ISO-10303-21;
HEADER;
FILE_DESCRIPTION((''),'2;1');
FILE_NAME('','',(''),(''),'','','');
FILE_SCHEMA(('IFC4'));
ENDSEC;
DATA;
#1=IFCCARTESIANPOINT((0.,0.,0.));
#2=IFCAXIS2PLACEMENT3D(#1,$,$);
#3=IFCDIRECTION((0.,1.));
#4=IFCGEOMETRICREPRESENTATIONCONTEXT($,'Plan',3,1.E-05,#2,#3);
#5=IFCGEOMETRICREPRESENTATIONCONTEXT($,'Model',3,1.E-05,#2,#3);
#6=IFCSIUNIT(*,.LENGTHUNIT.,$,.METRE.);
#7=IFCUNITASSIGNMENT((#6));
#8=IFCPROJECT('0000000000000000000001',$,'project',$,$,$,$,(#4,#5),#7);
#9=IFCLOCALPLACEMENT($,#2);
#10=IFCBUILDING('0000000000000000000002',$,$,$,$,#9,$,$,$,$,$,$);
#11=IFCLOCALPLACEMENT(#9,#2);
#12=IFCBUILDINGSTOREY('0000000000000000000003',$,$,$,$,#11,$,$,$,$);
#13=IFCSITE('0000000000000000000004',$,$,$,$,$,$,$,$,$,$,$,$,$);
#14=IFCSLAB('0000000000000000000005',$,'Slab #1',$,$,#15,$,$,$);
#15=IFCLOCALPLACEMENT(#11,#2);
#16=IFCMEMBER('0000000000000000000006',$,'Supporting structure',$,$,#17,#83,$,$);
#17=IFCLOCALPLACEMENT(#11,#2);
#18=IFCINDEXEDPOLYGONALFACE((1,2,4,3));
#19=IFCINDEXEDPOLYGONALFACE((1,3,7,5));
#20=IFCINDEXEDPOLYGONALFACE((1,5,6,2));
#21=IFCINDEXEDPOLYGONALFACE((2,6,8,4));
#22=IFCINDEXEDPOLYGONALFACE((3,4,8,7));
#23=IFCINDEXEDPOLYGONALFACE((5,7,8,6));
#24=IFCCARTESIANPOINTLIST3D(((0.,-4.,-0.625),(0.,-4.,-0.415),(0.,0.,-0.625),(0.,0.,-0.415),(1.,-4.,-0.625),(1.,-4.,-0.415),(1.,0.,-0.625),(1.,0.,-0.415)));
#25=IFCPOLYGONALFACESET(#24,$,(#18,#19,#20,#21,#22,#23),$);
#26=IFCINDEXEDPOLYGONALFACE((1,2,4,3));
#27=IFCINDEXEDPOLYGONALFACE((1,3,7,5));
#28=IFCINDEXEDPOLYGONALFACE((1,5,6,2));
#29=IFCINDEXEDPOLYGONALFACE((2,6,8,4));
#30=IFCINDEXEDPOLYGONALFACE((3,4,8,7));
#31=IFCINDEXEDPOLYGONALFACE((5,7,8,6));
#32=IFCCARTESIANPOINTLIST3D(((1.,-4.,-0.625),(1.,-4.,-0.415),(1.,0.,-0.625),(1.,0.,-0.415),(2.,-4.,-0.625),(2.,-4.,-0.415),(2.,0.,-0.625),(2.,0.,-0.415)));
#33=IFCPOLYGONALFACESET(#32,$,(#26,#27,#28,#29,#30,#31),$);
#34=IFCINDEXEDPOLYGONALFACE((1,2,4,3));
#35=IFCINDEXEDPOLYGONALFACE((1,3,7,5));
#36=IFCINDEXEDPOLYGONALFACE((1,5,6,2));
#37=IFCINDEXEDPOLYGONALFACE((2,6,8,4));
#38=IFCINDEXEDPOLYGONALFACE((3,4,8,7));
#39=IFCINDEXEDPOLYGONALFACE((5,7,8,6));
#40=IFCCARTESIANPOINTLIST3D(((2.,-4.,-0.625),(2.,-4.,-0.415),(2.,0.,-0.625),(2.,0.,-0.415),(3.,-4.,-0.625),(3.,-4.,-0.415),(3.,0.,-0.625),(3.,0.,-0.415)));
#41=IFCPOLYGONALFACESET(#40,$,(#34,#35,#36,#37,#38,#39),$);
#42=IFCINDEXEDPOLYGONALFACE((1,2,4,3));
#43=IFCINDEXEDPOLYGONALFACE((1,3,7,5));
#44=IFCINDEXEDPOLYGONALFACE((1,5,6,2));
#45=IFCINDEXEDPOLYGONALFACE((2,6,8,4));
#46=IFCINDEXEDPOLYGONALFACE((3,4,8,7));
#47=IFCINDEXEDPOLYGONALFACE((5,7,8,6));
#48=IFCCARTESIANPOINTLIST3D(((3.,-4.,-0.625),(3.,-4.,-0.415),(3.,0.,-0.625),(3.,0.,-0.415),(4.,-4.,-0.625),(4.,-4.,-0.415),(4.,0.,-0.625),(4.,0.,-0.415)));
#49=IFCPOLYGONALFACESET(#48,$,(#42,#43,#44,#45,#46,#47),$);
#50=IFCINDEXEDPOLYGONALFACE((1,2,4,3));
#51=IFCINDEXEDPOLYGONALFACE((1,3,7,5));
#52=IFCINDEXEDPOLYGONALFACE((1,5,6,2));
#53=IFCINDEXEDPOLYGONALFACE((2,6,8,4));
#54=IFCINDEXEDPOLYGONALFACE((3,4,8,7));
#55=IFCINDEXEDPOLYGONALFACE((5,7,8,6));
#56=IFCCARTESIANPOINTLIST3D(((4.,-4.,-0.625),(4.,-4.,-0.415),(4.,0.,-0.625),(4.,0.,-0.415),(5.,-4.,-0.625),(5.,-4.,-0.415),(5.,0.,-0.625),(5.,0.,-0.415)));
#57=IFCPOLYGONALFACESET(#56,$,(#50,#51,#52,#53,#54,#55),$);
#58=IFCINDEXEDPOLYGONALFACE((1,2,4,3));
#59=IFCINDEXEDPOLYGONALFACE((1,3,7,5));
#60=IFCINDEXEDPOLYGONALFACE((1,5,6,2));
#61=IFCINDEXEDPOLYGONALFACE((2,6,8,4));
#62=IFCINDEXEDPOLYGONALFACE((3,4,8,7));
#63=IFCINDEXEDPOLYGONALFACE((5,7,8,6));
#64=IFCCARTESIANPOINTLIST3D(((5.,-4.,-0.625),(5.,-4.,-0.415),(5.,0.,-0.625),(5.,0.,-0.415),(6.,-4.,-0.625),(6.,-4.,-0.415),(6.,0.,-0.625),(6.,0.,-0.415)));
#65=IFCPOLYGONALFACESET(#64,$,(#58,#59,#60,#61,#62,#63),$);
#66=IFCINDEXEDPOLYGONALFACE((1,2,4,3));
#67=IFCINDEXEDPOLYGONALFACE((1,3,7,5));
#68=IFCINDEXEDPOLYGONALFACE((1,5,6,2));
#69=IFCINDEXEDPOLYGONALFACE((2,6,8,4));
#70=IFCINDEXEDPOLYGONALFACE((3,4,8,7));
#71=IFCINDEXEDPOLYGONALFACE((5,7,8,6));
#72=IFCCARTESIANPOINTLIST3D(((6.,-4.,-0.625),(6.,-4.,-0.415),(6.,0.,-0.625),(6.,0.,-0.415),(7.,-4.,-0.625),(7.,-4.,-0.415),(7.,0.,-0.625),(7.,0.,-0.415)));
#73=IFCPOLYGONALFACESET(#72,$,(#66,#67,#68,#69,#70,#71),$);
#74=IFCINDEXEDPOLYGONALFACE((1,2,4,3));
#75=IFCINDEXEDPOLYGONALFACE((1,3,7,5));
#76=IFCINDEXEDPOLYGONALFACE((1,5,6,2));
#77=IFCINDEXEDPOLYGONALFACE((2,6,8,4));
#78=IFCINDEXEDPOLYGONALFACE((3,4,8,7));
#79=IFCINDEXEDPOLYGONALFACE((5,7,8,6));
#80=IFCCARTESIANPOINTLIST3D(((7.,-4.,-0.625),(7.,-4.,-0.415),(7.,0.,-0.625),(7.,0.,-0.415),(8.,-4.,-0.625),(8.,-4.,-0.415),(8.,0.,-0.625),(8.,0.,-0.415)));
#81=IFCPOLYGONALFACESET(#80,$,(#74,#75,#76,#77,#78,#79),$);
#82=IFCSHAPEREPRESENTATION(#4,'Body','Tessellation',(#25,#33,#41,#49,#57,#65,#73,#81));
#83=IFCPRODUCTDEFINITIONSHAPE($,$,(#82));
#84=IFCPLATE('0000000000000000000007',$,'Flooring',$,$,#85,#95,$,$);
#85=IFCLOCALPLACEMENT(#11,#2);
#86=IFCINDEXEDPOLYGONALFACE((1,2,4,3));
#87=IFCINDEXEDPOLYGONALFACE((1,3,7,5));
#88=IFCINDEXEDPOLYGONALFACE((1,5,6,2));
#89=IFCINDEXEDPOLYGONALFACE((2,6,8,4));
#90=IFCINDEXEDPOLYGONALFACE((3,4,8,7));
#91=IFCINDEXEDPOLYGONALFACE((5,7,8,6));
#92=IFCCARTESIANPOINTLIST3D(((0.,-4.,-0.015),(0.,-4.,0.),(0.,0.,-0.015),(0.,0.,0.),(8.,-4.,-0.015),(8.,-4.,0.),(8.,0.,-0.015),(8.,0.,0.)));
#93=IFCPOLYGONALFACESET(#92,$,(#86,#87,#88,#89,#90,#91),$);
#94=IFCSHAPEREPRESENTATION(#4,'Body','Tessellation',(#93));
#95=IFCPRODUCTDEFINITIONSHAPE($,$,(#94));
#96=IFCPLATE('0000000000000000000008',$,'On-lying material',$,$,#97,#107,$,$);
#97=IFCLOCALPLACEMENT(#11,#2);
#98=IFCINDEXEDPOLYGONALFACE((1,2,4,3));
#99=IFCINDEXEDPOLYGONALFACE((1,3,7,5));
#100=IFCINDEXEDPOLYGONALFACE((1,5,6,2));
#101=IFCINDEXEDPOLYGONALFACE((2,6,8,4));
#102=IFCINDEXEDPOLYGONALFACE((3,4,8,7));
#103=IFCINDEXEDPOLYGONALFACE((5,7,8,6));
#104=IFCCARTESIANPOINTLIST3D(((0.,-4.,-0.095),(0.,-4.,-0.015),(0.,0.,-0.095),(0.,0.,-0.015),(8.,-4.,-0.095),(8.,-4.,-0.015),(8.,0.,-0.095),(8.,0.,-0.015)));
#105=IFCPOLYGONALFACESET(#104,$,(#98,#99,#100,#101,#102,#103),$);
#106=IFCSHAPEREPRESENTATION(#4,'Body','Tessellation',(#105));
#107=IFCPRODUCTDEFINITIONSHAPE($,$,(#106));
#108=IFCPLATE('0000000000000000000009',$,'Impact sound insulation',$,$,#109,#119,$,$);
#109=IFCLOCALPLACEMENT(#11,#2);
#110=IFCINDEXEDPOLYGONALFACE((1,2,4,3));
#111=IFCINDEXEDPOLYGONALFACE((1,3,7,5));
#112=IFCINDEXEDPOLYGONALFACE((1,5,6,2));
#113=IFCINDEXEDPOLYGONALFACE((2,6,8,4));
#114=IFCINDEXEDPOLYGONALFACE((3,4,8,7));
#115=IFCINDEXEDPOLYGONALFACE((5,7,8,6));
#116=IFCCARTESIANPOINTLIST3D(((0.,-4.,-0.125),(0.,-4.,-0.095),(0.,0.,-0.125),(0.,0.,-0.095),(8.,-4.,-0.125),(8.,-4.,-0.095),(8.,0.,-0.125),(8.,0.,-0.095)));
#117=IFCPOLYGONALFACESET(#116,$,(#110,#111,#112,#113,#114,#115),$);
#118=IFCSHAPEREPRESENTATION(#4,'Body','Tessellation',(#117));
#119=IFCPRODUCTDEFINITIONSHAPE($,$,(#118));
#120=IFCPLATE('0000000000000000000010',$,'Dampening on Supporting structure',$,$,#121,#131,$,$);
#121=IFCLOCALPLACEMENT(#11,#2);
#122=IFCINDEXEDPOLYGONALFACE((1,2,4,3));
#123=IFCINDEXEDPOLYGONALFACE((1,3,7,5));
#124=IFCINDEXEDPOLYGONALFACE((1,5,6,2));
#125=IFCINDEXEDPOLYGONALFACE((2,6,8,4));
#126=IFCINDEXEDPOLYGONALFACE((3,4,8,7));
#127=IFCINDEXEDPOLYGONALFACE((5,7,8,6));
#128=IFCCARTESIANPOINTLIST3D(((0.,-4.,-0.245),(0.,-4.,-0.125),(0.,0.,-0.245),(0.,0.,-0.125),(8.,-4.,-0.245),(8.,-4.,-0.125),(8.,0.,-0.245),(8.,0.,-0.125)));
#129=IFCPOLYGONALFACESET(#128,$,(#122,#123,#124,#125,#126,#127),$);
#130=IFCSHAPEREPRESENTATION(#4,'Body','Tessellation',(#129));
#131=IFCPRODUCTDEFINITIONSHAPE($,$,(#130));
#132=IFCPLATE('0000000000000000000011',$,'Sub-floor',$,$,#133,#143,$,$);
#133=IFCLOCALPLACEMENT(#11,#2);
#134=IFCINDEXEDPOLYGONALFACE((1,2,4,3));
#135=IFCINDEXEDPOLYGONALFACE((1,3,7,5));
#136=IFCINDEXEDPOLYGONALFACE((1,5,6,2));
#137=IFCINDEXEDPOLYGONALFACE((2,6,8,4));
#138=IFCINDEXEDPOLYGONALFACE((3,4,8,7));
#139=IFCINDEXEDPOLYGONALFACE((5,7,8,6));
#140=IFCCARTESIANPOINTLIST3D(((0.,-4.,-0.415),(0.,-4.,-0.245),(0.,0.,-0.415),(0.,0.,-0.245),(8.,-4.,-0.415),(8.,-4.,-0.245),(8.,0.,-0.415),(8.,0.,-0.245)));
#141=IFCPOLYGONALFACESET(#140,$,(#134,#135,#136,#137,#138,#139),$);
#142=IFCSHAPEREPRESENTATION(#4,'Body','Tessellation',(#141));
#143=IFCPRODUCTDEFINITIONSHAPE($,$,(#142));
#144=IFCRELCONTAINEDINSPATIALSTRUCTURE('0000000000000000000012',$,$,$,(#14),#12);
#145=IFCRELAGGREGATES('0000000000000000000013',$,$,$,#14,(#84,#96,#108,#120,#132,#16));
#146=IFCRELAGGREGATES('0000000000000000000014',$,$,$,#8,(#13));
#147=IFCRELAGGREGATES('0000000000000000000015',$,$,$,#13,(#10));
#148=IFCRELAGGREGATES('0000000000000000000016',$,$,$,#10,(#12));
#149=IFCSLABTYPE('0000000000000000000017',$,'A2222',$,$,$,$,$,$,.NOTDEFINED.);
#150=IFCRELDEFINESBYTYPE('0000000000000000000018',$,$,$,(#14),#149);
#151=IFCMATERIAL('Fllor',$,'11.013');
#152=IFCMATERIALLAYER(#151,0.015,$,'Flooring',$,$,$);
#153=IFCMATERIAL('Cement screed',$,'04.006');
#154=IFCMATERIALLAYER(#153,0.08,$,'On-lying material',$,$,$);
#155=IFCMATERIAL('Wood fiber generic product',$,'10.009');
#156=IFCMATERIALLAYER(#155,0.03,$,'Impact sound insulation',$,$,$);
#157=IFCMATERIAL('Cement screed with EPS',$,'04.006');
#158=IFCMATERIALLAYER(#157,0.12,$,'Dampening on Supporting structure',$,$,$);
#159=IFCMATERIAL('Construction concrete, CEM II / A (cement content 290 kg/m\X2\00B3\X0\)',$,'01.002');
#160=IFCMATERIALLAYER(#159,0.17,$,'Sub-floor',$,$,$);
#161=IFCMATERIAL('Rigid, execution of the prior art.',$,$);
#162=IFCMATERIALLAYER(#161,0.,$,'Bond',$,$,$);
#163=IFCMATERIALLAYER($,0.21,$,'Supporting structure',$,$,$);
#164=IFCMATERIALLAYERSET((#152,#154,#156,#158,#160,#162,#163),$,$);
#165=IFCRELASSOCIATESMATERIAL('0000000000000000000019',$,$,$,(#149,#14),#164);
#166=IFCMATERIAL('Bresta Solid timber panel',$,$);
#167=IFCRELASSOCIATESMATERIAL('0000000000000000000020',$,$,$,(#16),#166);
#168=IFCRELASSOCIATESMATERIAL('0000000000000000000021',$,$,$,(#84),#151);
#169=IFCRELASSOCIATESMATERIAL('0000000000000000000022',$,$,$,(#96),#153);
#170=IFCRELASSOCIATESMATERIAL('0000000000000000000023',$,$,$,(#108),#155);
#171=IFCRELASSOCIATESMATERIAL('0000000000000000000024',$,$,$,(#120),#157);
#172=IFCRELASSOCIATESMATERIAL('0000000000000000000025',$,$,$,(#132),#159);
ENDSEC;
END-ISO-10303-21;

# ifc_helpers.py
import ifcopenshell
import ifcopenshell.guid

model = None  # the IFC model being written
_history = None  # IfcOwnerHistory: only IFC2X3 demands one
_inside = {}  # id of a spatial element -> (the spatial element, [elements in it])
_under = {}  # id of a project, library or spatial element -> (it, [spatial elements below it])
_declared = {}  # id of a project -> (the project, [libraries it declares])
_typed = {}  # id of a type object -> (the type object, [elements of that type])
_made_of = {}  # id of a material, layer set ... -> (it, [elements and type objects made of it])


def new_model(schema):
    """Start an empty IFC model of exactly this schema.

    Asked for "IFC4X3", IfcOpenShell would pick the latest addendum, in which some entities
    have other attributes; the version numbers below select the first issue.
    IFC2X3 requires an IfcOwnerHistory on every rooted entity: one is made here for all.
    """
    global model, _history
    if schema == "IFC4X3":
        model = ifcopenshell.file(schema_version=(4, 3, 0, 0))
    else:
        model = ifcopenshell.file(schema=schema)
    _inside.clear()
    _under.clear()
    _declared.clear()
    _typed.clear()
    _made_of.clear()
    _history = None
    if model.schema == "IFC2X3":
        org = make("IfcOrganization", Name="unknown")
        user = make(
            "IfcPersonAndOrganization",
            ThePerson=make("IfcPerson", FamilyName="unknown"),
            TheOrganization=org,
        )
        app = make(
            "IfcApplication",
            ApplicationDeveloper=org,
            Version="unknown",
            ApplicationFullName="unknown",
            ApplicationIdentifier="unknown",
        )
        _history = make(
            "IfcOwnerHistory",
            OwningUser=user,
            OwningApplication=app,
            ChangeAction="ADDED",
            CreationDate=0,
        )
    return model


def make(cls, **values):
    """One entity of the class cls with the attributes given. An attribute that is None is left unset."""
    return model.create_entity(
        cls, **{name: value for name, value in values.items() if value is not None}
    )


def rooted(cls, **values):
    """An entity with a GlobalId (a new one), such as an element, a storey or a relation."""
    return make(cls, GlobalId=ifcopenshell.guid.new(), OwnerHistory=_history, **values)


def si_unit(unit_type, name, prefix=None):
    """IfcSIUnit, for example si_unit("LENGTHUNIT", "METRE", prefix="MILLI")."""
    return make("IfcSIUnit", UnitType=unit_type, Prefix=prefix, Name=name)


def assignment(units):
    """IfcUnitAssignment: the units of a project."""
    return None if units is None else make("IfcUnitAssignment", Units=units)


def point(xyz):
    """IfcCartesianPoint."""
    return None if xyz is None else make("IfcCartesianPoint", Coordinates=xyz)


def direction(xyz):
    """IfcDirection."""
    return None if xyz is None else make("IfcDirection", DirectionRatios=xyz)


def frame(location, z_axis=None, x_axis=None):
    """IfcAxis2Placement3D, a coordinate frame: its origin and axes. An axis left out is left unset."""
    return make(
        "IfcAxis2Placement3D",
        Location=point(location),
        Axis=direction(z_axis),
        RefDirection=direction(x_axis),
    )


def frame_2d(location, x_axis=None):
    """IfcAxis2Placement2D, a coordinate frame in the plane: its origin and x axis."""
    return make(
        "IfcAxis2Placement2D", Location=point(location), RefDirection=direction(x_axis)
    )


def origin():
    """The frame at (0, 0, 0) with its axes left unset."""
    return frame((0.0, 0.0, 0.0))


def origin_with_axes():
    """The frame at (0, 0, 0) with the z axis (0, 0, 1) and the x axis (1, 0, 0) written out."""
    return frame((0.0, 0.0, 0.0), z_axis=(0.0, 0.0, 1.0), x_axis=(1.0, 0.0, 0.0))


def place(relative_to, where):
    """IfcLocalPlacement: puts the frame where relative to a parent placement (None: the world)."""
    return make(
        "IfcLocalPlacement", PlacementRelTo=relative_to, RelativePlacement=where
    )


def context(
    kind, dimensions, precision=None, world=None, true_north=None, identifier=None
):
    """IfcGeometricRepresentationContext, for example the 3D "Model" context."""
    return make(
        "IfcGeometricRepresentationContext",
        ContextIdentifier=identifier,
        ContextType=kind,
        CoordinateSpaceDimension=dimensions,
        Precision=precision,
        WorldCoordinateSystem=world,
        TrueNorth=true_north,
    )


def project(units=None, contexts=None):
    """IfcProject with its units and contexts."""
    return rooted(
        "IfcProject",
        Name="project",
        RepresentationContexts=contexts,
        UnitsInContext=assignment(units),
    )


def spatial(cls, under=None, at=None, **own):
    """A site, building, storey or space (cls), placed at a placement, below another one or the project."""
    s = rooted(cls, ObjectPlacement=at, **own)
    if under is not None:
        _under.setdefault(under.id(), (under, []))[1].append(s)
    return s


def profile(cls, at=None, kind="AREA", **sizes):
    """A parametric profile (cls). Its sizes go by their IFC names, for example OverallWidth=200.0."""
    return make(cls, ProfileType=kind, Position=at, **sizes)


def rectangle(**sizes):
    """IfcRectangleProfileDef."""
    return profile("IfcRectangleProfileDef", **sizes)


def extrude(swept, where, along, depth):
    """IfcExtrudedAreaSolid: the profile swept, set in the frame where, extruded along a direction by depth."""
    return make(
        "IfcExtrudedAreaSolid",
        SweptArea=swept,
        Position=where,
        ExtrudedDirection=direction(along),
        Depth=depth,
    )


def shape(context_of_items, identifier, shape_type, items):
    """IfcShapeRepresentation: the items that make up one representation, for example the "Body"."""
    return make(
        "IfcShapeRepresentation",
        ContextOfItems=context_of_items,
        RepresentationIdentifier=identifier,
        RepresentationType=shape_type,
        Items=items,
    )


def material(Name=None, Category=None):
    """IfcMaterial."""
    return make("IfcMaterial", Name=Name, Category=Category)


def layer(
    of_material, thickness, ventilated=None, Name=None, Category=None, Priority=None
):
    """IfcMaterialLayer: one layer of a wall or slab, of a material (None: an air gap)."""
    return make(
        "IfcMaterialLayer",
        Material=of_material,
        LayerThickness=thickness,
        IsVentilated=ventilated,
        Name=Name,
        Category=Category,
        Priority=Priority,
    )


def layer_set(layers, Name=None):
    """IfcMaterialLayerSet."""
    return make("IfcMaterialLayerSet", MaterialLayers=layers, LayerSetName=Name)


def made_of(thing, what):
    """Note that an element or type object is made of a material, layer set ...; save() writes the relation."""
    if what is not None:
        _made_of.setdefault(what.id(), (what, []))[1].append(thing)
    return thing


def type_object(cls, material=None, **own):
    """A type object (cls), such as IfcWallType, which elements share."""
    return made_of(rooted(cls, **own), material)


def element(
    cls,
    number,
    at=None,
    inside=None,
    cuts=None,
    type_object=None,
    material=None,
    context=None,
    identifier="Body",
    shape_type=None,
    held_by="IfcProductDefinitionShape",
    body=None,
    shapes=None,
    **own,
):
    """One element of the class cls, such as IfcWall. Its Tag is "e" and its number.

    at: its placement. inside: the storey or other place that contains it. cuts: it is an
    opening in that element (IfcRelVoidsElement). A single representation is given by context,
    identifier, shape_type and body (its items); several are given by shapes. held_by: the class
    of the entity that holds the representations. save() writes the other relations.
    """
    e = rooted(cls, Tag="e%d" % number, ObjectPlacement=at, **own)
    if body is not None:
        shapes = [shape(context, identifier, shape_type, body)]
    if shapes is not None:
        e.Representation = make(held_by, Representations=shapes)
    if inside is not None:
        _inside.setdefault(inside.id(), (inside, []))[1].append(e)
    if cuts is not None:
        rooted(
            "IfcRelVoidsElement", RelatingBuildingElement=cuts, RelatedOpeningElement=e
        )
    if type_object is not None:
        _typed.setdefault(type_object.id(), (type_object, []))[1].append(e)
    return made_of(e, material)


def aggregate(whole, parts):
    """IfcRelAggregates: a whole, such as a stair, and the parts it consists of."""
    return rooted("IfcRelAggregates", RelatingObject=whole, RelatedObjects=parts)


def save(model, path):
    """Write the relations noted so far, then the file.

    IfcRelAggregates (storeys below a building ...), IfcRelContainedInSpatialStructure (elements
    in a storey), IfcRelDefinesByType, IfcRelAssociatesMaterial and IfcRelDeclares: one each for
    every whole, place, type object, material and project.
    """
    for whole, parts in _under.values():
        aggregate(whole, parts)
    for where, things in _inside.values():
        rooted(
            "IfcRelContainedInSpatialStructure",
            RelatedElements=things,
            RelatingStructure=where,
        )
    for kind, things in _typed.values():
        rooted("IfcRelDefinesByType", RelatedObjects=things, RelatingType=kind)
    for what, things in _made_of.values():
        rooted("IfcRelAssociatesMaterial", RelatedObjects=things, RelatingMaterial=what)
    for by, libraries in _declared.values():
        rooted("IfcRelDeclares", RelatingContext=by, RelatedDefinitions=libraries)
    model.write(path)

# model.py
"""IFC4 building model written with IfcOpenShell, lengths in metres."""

from ifc_helpers import new_model, si_unit, direction, frame, frame_2d, origin, origin_with_axes, place, context, project, spatial, rectangle, extrude, material, layer, layer_set, type_object, element, aggregate, save


model = new_model("IFC4")

# Units and contexts
plan_context = context("Plan", 3, precision=1e-05, world=origin(), true_north=direction((0.0, 1.0)))
model_context = context("Model", 3, precision=1e-05, world=origin(), true_north=direction((0.0, 1.0)))
ifc_project = project(units=[si_unit("LENGTHUNIT", "METRE")], contexts=[plan_context, model_context])

# Site, building, storey
site = spatial("IfcSite", under=ifc_project)
building_placement = place(None, origin())
building = spatial("IfcBuilding", under=site, at=building_placement)
storey_placement = place(building_placement, origin())
storey = spatial("IfcBuildingStorey", under=building, at=storey_placement)

# Slab, member, plates
ifc_material_1 = material(Name="Fllor", Category="11.013")
ifc_layer_1 = layer(ifc_material_1, 0.015, Name="Flooring")
ifc_material_2 = material(Name="Cement screed", Category="04.006")
ifc_layer_2 = layer(ifc_material_2, 0.08, Name="On-lying material")
ifc_material_3 = material(Name="Wood fiber generic product", Category="10.009")
ifc_layer_3 = layer(ifc_material_3, 0.03, Name="Impact sound insulation")
ifc_material_4 = material(Name="Cement screed with EPS", Category="04.006")
ifc_layer_4 = layer(ifc_material_4, 0.12, Name="Dampening on Supporting structure")
ifc_material_5 = material(Name="Construction concrete, CEM II / A (cement content 290 kg/m³)", Category="01.002")
ifc_layer_5 = layer(ifc_material_5, 0.17, Name="Sub-floor")
ifc_material_6 = material(Name="Rigid, execution of the prior art.")
ifc_layer_6 = layer(ifc_material_6, 0.0, Name="Bond")
ifc_layer_7 = layer(None, 0.21, Name="Supporting structure")
ifc_layer_set = layer_set([ifc_layer_1, ifc_layer_2, ifc_layer_3, ifc_layer_4, ifc_layer_5, ifc_layer_6, ifc_layer_7])
slab_type = type_object("IfcSlabType", Name="A2222", PredefinedType="NOTDEFINED", material=ifc_layer_set)
slab_placement = place(None, frame((0.0, 0.0, 0.0), z_axis=(0.0, 0.0, -1.0), x_axis=(1.0, 0.0, 0.0)))
slab = element("IfcSlab", 1, at=slab_placement, inside=storey, type_object=slab_type, material=ifc_layer_set, Name="Slab #1")
ifc_material_7 = material(Name="Bresta Solid timber panel")
member_placement = place(slab_placement, origin())
member = element("IfcMember", 2, at=member_placement, material=ifc_material_7, Name="Supporting structure", context=plan_context, shape_type="SweptSolid", body=[
    extrude(rectangle(XDim=1.0, YDim=0.21, at=frame_2d((0.5, 0.105), x_axis=(1.0, 0.0))), frame((0.0, 4.0, 0.415), z_axis=(0.0, -1.0, 0.0), x_axis=(1.0, 0.0, 0.0)), (0.0, 0.0, 1.0), 4.0),
    extrude(rectangle(XDim=1.0, YDim=0.21, at=frame_2d((0.5, 0.105), x_axis=(1.0, 0.0))), frame((1.0, 4.0, 0.415), z_axis=(0.0, -1.0, 0.0), x_axis=(1.0, 0.0, 0.0)), (0.0, 0.0, 1.0), 4.0),
    extrude(rectangle(XDim=1.0, YDim=0.21, at=frame_2d((0.5, 0.105), x_axis=(1.0, 0.0))), frame((2.0, 4.0, 0.415), z_axis=(0.0, -1.0, 0.0), x_axis=(1.0, 0.0, 0.0)), (0.0, 0.0, 1.0), 4.0),
    extrude(rectangle(XDim=1.0, YDim=0.21, at=frame_2d((0.5, 0.105), x_axis=(1.0, 0.0))), frame((3.0, 4.0, 0.415), z_axis=(0.0, -1.0, 0.0), x_axis=(1.0, 0.0, 0.0)), (0.0, 0.0, 1.0), 4.0),
    extrude(rectangle(XDim=1.0, YDim=0.21, at=frame_2d((0.5, 0.105), x_axis=(1.0, 0.0))), frame((4.0, 4.0, 0.415), z_axis=(0.0, -1.0, 0.0), x_axis=(1.0, 0.0, 0.0)), (0.0, 0.0, 1.0), 4.0),
    extrude(rectangle(XDim=1.0, YDim=0.21, at=frame_2d((0.5, 0.105), x_axis=(1.0, 0.0))), frame((5.0, 4.0, 0.415), z_axis=(0.0, -1.0, 0.0), x_axis=(1.0, 0.0, 0.0)), (0.0, 0.0, 1.0), 4.0),
    extrude(rectangle(XDim=1.0, YDim=0.21, at=frame_2d((0.5, 0.105), x_axis=(1.0, 0.0))), frame((6.0, 4.0, 0.415), z_axis=(0.0, -1.0, 0.0), x_axis=(1.0, 0.0, 0.0)), (0.0, 0.0, 1.0), 4.0),
    extrude(rectangle(XDim=1.0, YDim=0.21, at=frame_2d((0.5, 0.105), x_axis=(1.0, 0.0))), frame((7.0, 4.0, 0.415), z_axis=(0.0, -1.0, 0.0), x_axis=(1.0, 0.0, 0.0)), (0.0, 0.0, 1.0), 4.0),
])
plate_1_placement = place(slab_placement, origin())
plate_1 = element("IfcPlate", 3, at=plate_1_placement, material=ifc_material_1, Name="Flooring", context=plan_context, shape_type="SweptSolid", body=[
    extrude(rectangle(XDim=8.0, YDim=4.0, at=frame_2d((4.0, 2.0), x_axis=(1.0, 0.0))), origin_with_axes(), (0.0, 0.0, 1.0), 0.015),
])
plate_2_placement = place(slab_placement, origin())
plate_2 = element("IfcPlate", 4, at=plate_2_placement, material=ifc_material_2, Name="On-lying material", context=plan_context, shape_type="SweptSolid", body=[
    extrude(rectangle(XDim=8.0, YDim=4.0, at=frame_2d((4.0, 2.0), x_axis=(1.0, 0.0))), frame((0.0, 0.0, 0.015), z_axis=(0.0, 0.0, 1.0), x_axis=(1.0, 0.0, 0.0)), (0.0, 0.0, 1.0), 0.08),
])
plate_3_placement = place(slab_placement, origin())
plate_3 = element("IfcPlate", 5, at=plate_3_placement, material=ifc_material_3, Name="Impact sound insulation", context=plan_context, shape_type="SweptSolid", body=[
    extrude(rectangle(XDim=8.0, YDim=4.0, at=frame_2d((4.0, 2.0), x_axis=(1.0, 0.0))), frame((0.0, 0.0, 0.095), z_axis=(0.0, 0.0, 1.0), x_axis=(1.0, 0.0, 0.0)), (0.0, 0.0, 1.0), 0.03),
])
plate_4_placement = place(slab_placement, origin())
plate_4 = element("IfcPlate", 6, at=plate_4_placement, material=ifc_material_4, Name="Dampening on Supporting structure", context=plan_context, shape_type="SweptSolid", body=[
    extrude(rectangle(XDim=8.0, YDim=4.0, at=frame_2d((4.0, 2.0), x_axis=(1.0, 0.0))), frame((0.0, 0.0, 0.125), z_axis=(0.0, 0.0, 1.0), x_axis=(1.0, 0.0, 0.0)), (0.0, 0.0, 1.0), 0.12),
])
plate_5_placement = place(slab_placement, origin())
plate_5 = element("IfcPlate", 7, at=plate_5_placement, material=ifc_material_5, Name="Sub-floor", context=plan_context, shape_type="SweptSolid", body=[
    extrude(rectangle(XDim=8.0, YDim=4.0, at=frame_2d((4.0, 2.0), x_axis=(1.0, 0.0))), frame((0.0, 0.0, 0.245), z_axis=(0.0, 0.0, 1.0), x_axis=(1.0, 0.0, 0.0)), (0.0, 0.0, 1.0), 0.17),
])
aggregate(slab, [plate_1, plate_2, plate_3, plate_4, plate_5, member])

save(model, "model.ifc")
